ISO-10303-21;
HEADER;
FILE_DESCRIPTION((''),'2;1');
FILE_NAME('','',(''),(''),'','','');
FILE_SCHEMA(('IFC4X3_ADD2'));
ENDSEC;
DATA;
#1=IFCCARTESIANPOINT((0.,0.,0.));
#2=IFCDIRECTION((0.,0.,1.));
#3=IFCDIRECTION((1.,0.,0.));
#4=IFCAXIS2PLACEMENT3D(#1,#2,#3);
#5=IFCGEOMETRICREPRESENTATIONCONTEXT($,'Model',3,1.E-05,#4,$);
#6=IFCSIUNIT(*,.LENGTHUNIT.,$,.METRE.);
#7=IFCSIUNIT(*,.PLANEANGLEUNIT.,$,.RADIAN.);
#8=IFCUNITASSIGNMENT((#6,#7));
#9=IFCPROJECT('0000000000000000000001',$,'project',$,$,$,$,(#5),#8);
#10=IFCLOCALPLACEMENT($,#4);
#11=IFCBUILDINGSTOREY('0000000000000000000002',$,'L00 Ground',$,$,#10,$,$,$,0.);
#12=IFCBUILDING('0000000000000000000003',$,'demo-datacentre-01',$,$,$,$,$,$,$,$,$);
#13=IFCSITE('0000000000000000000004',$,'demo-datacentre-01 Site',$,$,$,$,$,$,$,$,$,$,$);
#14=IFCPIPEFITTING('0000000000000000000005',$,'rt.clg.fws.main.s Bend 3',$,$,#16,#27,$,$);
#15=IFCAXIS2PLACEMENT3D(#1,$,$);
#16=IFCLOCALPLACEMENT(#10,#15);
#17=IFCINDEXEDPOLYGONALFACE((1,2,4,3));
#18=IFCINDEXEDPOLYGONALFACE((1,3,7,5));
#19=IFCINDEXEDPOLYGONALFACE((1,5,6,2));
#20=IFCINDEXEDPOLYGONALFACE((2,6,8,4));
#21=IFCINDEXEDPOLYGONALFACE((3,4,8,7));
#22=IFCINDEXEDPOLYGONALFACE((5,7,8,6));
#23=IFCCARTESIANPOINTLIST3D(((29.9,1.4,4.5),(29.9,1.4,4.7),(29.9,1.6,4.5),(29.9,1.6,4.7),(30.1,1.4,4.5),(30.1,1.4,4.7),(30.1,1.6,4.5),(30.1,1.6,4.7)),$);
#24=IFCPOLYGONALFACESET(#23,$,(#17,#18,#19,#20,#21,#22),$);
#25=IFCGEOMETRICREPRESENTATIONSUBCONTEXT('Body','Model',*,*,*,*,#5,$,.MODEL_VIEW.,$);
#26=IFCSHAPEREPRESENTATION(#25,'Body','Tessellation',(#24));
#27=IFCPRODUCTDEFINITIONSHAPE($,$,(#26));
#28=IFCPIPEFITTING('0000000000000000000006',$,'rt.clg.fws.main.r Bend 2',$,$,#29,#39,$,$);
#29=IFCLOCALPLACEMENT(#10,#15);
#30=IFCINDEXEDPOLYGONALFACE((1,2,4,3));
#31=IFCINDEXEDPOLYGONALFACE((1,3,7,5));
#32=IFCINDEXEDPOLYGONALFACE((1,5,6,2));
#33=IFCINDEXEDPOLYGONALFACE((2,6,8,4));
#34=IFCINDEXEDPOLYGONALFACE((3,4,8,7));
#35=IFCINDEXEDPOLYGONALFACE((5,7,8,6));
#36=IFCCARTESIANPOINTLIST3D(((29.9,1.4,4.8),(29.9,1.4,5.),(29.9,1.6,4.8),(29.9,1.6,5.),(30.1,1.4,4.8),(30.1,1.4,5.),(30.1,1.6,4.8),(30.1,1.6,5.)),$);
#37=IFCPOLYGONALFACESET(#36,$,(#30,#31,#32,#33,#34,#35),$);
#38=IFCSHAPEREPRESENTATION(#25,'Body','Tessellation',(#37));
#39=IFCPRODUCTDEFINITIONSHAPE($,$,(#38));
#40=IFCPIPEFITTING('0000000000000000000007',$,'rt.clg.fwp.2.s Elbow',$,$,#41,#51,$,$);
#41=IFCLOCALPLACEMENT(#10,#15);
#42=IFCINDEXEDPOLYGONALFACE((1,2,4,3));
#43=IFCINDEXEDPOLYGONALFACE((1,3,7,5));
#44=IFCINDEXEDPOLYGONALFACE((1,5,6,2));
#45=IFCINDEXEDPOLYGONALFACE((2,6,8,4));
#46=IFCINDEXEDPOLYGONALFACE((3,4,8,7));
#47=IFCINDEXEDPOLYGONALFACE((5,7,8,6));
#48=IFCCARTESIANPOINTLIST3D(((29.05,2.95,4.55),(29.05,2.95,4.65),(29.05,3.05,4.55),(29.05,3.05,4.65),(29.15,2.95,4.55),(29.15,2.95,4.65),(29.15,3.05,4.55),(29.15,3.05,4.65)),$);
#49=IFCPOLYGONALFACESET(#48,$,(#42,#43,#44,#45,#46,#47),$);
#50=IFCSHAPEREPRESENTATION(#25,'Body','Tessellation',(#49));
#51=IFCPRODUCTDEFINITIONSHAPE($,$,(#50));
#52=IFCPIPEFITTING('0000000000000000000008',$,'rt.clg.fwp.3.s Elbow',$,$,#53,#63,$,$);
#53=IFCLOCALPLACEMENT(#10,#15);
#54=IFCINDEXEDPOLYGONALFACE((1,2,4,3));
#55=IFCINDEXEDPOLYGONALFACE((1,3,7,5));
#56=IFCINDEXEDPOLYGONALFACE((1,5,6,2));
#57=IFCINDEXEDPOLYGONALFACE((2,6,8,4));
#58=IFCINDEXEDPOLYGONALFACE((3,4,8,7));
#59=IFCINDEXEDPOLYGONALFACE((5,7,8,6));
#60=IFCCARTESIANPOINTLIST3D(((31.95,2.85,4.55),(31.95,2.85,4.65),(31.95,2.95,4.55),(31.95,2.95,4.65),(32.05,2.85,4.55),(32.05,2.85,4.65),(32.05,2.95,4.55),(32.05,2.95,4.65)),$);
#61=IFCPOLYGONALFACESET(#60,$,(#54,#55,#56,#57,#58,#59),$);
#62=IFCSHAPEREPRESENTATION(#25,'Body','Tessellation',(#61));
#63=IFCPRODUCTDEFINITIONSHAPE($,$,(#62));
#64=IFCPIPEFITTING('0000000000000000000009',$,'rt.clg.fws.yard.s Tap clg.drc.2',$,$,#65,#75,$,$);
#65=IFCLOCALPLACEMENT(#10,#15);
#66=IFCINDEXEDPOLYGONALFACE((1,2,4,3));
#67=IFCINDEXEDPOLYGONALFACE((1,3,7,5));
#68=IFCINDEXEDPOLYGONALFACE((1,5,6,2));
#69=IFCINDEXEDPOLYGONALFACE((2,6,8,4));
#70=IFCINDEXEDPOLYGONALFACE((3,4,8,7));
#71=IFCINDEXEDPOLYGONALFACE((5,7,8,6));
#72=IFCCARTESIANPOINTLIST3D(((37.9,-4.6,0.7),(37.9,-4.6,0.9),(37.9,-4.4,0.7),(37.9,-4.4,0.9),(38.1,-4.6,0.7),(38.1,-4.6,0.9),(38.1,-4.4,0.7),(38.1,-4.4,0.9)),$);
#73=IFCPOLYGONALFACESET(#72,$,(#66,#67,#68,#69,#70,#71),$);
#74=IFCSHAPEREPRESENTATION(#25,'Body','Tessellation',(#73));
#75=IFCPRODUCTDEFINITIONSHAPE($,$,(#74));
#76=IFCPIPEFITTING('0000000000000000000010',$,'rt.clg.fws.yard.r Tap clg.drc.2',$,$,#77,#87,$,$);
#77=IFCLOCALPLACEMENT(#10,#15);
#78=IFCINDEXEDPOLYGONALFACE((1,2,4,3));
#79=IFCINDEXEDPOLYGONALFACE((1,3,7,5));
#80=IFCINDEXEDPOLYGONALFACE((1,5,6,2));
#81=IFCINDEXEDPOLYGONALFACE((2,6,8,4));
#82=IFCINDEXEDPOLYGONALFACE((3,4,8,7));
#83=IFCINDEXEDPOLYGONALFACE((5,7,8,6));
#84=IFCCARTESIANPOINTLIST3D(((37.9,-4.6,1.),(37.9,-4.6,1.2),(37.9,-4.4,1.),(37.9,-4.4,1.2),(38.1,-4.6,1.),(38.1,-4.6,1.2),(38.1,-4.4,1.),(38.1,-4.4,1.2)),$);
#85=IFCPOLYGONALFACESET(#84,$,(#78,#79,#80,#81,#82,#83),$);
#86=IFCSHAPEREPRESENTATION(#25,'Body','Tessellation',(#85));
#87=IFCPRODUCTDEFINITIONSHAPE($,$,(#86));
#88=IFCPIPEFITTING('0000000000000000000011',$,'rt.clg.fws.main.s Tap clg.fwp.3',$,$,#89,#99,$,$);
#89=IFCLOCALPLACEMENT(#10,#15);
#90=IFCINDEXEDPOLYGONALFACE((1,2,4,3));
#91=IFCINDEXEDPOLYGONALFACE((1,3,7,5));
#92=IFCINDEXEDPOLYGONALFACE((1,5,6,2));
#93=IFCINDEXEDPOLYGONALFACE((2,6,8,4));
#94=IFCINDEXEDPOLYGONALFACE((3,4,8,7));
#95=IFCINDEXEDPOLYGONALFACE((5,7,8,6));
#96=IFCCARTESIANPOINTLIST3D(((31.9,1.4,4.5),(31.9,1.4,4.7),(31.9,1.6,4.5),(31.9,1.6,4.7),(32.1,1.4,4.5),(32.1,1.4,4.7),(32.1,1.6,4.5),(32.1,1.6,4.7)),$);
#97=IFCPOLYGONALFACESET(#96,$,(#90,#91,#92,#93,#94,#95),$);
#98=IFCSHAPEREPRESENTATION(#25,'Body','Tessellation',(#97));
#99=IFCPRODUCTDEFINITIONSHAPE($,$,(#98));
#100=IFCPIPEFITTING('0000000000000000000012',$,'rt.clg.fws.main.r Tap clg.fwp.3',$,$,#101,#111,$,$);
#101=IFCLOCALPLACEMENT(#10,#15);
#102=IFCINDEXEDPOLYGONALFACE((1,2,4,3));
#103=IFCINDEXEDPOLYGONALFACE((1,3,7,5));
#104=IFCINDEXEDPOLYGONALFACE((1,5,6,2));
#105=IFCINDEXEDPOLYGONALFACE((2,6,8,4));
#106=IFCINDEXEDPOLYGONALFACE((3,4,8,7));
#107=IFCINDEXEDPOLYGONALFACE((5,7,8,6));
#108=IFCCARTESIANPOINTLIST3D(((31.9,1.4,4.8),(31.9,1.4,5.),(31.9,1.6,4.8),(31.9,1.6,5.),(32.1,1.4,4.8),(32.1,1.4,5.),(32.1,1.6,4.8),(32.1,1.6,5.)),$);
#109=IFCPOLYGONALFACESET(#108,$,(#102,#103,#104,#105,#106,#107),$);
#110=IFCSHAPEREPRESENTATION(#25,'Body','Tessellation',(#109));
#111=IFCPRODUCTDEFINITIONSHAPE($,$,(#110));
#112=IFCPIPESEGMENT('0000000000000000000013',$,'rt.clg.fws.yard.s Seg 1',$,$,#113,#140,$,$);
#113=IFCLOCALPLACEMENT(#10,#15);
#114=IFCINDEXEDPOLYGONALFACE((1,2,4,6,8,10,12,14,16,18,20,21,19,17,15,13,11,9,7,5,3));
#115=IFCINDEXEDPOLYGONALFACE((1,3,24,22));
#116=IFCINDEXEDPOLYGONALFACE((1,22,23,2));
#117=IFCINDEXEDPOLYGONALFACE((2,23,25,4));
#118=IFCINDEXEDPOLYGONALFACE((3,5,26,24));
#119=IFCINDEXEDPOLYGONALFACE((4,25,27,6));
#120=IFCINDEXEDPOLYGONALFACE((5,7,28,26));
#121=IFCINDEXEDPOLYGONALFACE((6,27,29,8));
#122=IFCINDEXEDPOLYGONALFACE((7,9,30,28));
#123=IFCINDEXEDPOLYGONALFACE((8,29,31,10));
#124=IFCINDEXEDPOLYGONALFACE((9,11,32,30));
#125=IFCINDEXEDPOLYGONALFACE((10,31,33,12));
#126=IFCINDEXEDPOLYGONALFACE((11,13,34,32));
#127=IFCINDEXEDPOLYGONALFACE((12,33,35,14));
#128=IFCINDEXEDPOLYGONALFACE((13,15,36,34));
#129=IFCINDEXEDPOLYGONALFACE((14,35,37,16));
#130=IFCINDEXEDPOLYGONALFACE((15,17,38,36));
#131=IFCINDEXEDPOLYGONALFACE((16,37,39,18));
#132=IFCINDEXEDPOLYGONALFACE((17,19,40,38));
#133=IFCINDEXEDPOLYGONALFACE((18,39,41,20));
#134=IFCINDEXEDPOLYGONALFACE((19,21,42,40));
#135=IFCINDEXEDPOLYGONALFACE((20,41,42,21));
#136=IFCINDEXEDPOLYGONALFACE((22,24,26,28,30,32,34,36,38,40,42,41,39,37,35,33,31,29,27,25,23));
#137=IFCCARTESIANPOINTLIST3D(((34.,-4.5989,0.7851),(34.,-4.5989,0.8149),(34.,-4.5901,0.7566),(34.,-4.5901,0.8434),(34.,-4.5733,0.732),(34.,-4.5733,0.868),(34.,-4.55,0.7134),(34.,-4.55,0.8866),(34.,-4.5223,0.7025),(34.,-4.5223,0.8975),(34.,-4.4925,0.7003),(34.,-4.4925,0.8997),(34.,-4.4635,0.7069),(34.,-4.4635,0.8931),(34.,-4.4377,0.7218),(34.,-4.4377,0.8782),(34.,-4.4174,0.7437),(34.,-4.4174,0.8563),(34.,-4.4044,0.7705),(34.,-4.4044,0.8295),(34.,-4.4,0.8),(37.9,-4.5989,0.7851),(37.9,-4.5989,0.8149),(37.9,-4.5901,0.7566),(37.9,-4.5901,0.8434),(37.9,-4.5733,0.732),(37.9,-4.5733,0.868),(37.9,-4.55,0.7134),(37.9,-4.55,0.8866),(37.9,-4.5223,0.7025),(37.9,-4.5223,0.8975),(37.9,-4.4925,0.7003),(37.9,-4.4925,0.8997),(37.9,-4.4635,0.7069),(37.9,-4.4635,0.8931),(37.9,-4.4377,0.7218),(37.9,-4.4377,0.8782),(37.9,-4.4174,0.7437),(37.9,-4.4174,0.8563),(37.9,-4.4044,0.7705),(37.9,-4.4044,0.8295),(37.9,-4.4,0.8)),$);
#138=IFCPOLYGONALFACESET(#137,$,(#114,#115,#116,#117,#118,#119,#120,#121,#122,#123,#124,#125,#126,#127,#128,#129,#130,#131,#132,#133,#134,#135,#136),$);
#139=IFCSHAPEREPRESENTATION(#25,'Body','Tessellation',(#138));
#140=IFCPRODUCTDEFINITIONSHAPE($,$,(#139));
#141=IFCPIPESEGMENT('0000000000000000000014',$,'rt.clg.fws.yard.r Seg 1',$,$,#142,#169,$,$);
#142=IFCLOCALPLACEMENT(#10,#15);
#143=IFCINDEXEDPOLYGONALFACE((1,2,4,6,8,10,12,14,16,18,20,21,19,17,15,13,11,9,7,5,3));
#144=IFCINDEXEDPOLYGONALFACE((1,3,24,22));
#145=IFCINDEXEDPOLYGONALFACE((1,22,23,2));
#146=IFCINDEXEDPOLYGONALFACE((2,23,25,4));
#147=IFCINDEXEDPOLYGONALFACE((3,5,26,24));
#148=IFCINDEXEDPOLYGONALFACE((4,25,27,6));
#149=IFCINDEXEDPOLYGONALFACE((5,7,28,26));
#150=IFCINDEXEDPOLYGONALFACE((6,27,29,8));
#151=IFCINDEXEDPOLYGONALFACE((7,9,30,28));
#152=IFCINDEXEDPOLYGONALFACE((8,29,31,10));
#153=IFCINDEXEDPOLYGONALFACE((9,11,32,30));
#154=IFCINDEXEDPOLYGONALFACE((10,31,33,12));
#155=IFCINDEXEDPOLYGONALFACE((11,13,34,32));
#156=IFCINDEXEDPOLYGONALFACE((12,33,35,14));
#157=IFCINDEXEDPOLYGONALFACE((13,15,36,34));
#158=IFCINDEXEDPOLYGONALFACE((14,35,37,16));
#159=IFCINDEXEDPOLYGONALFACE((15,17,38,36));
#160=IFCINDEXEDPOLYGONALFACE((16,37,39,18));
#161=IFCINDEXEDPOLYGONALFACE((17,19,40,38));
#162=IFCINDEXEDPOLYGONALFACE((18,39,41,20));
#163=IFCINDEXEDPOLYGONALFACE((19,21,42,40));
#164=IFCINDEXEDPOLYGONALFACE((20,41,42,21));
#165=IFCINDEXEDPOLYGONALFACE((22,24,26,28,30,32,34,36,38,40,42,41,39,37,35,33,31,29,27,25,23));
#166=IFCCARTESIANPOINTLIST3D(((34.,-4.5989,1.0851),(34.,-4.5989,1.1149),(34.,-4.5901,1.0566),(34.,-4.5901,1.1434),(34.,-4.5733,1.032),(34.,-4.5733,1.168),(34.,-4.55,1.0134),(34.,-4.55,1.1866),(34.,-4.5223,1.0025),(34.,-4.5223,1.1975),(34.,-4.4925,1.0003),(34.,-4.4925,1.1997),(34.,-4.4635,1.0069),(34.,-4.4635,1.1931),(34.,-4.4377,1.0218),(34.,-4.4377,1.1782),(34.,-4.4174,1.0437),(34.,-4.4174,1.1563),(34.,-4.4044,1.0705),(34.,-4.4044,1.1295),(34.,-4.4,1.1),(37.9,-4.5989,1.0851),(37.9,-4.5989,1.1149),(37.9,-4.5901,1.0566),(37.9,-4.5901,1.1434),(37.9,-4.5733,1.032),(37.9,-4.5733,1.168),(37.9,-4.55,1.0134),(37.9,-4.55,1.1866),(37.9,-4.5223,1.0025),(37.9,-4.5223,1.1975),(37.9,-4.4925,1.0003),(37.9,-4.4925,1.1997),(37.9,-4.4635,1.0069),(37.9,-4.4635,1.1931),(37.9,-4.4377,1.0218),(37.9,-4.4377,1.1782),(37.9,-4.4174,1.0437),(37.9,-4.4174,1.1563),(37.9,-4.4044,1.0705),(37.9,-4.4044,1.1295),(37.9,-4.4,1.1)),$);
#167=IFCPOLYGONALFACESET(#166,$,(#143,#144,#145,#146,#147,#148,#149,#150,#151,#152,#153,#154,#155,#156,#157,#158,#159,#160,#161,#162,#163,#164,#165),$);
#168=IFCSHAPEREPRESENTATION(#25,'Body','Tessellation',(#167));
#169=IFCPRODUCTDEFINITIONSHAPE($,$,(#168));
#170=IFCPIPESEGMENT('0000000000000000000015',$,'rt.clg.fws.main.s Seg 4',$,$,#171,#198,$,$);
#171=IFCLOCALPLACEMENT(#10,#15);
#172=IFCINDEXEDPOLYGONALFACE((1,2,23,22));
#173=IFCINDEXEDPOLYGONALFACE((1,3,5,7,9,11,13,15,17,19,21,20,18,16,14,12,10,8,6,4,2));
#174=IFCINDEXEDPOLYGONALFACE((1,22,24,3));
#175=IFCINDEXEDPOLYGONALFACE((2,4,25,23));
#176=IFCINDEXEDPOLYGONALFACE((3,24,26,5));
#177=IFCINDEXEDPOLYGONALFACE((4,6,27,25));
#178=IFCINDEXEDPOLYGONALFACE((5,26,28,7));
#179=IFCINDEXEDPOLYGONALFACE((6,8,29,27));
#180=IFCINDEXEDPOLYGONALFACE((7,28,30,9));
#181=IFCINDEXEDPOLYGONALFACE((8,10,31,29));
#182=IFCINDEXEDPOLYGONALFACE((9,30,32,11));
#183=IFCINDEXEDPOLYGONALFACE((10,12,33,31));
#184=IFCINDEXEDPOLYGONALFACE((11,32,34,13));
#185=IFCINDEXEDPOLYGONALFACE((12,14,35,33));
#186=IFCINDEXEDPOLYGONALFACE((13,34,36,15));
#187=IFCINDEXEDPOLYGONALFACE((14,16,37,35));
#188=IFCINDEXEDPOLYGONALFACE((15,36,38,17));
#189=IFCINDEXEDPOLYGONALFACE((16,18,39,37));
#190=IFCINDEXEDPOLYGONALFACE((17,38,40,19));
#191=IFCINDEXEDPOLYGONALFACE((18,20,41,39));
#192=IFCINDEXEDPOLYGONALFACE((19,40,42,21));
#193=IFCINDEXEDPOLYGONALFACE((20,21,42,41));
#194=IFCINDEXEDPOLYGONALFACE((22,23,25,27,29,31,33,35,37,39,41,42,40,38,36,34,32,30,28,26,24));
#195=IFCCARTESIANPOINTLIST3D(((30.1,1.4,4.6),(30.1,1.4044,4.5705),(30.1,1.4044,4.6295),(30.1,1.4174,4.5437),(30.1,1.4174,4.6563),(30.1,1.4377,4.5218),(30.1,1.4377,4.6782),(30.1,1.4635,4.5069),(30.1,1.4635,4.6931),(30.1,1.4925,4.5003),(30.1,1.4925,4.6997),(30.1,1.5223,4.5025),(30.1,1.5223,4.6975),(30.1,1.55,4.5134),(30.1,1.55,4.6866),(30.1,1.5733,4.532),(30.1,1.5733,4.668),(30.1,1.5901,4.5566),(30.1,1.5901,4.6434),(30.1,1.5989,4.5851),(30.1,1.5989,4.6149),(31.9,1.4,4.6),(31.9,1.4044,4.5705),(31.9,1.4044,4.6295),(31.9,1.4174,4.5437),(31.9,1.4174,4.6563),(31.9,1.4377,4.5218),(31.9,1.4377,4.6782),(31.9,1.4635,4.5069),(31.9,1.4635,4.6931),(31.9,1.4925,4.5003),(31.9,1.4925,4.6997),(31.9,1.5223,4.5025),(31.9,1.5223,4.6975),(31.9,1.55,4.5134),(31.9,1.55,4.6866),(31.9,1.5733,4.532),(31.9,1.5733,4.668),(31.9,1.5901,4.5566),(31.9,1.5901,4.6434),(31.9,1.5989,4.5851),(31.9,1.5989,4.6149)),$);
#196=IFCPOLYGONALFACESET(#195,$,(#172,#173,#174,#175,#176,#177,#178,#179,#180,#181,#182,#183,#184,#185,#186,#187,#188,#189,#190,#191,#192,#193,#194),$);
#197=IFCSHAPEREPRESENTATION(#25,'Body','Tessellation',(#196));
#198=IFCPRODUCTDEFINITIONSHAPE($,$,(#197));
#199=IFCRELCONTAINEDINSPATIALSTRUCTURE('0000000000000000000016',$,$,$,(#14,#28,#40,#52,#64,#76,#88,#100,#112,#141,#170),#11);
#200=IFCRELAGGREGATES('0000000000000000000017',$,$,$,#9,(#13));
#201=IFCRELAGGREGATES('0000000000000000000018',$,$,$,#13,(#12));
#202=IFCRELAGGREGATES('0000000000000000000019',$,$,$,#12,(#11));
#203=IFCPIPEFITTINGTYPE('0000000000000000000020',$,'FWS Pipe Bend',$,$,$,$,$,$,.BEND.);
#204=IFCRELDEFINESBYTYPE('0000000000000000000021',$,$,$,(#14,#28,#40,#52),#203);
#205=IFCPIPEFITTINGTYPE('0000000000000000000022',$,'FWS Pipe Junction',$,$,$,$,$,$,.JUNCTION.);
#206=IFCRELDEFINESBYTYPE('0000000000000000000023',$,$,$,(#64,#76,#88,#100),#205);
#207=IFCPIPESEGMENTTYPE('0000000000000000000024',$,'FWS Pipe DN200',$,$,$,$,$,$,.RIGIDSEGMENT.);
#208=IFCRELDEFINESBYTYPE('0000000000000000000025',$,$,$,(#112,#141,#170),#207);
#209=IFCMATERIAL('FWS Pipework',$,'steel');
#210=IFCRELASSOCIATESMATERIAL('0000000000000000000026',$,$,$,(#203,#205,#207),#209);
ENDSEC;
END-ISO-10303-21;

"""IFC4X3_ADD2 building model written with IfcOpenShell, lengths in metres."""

from ifc_helpers import new_model, si_unit, frame, origin_with_axes, place, context, subcontext, project, spatial, rectangle, circle, extrude, material, type_object, element, save


model = new_model("IFC4X3_ADD2")

# Units and contexts
model_context = context("Model", 3, precision=1e-05, world=origin_with_axes())
body_context = subcontext(model_context, "Body", "Model", "MODEL_VIEW")
ifc_project = project(units=[si_unit("LENGTHUNIT", "METRE"), si_unit("PLANEANGLEUNIT", "RADIAN")], contexts=[model_context])

# Site, building, storey
site = spatial("IfcSite", under=ifc_project, Name="demo-datacentre-01 Site")
building = spatial("IfcBuilding", under=site, Name="demo-datacentre-01")
storey_placement = place(None, origin_with_axes())
storey = spatial("IfcBuildingStorey", under=building, at=storey_placement, Name="L00 Ground", Elevation=0.0)

# Pipe fittings
ifc_material = material(Name="FWS Pipework", Category="steel")
pipe_fitting_type_1 = type_object("IfcPipeFittingType", Name="FWS Pipe Bend", PredefinedType="BEND", material=ifc_material)
for number, where, z_axis, x_axis, name in (
    (1, (30.0, 1.5, 4.5), (0.0, 0.0, 1.0), (1.0, 0.0, 0.0), "rt.clg.fws.main.s Bend 3"),
    (2, (30.0, 1.5, 4.8), (0.0, 0.0, 1.0), (1.0, 0.0, 0.0), "rt.clg.fws.main.r Bend 2"),
):
    element("IfcPipeFitting", number, at=place(storey_placement, frame(where, z_axis=z_axis, x_axis=x_axis)), inside=storey, type_object=pipe_fitting_type_1, Name=name, context=body_context, shape_type="SweptSolid", body=[
        extrude(rectangle(XDim=0.2, YDim=0.2), origin_with_axes(), (0.0, 0.0, 1.0), 0.2),
    ])
for number, where, z_axis, x_axis, name in (
    (3, (29.1, 3.0, 4.55), (0.0, 0.0, 1.0), (1.0, 0.0, 0.0), "rt.clg.fwp.2.s Elbow"),
    (4, (32.0, 2.9, 4.55), (0.0, 0.0, 1.0), (1.0, 0.0, 0.0), "rt.clg.fwp.3.s Elbow"),
):
    element("IfcPipeFitting", number, at=place(storey_placement, frame(where, z_axis=z_axis, x_axis=x_axis)), inside=storey, type_object=pipe_fitting_type_1, Name=name, context=body_context, shape_type="SweptSolid", body=[
        extrude(rectangle(XDim=0.1, YDim=0.1), origin_with_axes(), (0.0, 0.0, 1.0), 0.1),
    ])
pipe_fitting_type_2 = type_object("IfcPipeFittingType", Name="FWS Pipe Junction", PredefinedType="JUNCTION", material=ifc_material)
for number, where, z_axis, x_axis, name in (
    (5, (38.0, -4.5, 0.7), (0.0, 0.0, 1.0), (1.0, 0.0, 0.0), "rt.clg.fws.yard.s Tap clg.drc.2"),
    (6, (38.0, -4.5, 1.0), (0.0, 0.0, 1.0), (1.0, 0.0, 0.0), "rt.clg.fws.yard.r Tap clg.drc.2"),
    (7, (32.0, 1.5, 4.5), (0.0, 0.0, 1.0), (1.0, 0.0, 0.0), "rt.clg.fws.main.s Tap clg.fwp.3"),
    (8, (32.0, 1.5, 4.8), (0.0, 0.0, 1.0), (1.0, 0.0, 0.0), "rt.clg.fws.main.r Tap clg.fwp.3"),
):
    element("IfcPipeFitting", number, at=place(storey_placement, frame(where, z_axis=z_axis, x_axis=x_axis)), inside=storey, type_object=pipe_fitting_type_2, Name=name, context=body_context, shape_type="SweptSolid", body=[
        extrude(rectangle(XDim=0.2, YDim=0.2), origin_with_axes(), (0.0, 0.0, 1.0), 0.2),
    ])

# Pipe segments
pipe_segment_type_1 = type_object("IfcPipeSegmentType", Name="FWS Pipe DN200", PredefinedType="RIGIDSEGMENT", material=ifc_material)
for number, where, z_axis, x_axis, name in (
    (9, (34.0, -4.5, 0.8), (1.0, 0.0, 0.0), (0.0, 1.0, 0.0), "rt.clg.fws.yard.s Seg 1"),
    (10, (34.0, -4.5, 1.1), (1.0, 0.0, 0.0), (0.0, 1.0, 0.0), "rt.clg.fws.yard.r Seg 1"),
):
    element("IfcPipeSegment", number, at=place(storey_placement, frame(where, z_axis=z_axis, x_axis=x_axis)), inside=storey, type_object=pipe_segment_type_1, Name=name, context=body_context, shape_type="SweptSolid", body=[
        extrude(circle(Radius=0.1), origin_with_axes(), (0.0, 0.0, 1.0), 3.9),
    ])
pipe_segment_1_placement = place(storey_placement, frame((31.9, 1.5, 4.6), z_axis=(-1.0, 0.0, 0.0), x_axis=(0.0, -1.0, 0.0)))
element("IfcPipeSegment", 11, at=pipe_segment_1_placement, inside=storey, type_object=pipe_segment_type_1, Name="rt.clg.fws.main.s Seg 4", context=body_context, shape_type="SweptSolid", body=[
    extrude(circle(Radius=0.1), origin_with_axes(), (0.0, 0.0, 1.0), 1.8),
])

save(model, "model.ifc")
